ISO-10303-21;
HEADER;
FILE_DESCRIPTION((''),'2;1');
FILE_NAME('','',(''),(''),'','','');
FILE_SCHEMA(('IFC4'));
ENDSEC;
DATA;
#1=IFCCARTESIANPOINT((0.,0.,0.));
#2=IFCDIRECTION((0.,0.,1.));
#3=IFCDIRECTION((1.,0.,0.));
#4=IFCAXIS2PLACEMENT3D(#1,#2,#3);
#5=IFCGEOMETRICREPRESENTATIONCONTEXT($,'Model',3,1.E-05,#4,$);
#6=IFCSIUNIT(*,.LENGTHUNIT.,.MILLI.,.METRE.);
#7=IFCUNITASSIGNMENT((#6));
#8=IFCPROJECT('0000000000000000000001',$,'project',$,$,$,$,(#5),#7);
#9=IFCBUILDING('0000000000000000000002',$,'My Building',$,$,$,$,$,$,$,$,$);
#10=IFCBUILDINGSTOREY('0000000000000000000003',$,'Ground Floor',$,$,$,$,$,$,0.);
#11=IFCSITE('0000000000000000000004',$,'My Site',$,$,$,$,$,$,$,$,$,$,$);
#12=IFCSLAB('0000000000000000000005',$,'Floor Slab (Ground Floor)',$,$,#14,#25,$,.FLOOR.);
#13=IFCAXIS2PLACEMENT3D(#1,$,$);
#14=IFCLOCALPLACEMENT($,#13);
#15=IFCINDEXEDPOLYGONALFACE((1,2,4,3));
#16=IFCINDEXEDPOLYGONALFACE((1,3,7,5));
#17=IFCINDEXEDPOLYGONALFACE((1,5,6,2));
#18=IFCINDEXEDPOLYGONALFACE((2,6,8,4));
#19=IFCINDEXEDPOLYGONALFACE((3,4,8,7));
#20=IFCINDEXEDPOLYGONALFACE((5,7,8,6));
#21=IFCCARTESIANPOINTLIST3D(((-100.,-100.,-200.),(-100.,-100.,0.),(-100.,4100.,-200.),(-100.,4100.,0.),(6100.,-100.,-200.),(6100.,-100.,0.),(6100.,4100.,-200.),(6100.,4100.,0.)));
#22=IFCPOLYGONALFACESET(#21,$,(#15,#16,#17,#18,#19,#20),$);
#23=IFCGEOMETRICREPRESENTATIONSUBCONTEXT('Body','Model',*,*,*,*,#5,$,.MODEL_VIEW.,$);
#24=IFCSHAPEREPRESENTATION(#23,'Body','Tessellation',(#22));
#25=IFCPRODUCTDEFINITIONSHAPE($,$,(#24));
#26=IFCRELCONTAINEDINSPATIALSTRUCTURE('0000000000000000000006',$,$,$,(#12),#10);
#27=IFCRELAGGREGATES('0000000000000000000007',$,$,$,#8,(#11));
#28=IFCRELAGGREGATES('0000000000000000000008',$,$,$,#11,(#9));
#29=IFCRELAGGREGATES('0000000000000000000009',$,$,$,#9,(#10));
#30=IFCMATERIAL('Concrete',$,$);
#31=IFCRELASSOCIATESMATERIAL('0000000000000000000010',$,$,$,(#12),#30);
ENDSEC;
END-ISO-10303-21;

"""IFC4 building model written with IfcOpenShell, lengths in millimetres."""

from ifc_helpers import new_model, si_unit, frame, origin_with_axes, place, context, subcontext, project, spatial, indexed_curve, outline, extrude, material, element, save


model = new_model("IFC4")

# Units and contexts
model_context = context("Model", 3, precision=1e-05, world=origin_with_axes())
body_context = subcontext(model_context, "Body", "Model", "MODEL_VIEW")
ifc_project = project(units=[si_unit("LENGTHUNIT", "METRE", prefix="MILLI")], contexts=[model_context])

# Site, building, storey
site = spatial("IfcSite", under=ifc_project, Name="My Site")
building = spatial("IfcBuilding", under=site, Name="My Building")
storey = spatial("IfcBuildingStorey", under=building, Name="Ground Floor", Elevation=0.0)

# Slab
ifc_material = material(Name="Concrete")
slab_placement = place(None, frame((0.0, 0.0, -200.0), z_axis=(0.0, 0.0, 1.0), x_axis=(1.0, 0.0, 0.0)))
element("IfcSlab", 1, at=slab_placement, inside=storey, material=ifc_material, Name="Floor Slab (Ground Floor)", PredefinedType="FLOOR", context=body_context, shape_type="SweptSolid", body=[
    extrude(outline(indexed_curve([(-100.0, -100.0), (6100.0, -100.0), (6100.0, 4100.0), (-100.0, 4100.0)])), None, (0.0, 0.0, 1.0), 200.0),
])

save(model, "model.ifc")
